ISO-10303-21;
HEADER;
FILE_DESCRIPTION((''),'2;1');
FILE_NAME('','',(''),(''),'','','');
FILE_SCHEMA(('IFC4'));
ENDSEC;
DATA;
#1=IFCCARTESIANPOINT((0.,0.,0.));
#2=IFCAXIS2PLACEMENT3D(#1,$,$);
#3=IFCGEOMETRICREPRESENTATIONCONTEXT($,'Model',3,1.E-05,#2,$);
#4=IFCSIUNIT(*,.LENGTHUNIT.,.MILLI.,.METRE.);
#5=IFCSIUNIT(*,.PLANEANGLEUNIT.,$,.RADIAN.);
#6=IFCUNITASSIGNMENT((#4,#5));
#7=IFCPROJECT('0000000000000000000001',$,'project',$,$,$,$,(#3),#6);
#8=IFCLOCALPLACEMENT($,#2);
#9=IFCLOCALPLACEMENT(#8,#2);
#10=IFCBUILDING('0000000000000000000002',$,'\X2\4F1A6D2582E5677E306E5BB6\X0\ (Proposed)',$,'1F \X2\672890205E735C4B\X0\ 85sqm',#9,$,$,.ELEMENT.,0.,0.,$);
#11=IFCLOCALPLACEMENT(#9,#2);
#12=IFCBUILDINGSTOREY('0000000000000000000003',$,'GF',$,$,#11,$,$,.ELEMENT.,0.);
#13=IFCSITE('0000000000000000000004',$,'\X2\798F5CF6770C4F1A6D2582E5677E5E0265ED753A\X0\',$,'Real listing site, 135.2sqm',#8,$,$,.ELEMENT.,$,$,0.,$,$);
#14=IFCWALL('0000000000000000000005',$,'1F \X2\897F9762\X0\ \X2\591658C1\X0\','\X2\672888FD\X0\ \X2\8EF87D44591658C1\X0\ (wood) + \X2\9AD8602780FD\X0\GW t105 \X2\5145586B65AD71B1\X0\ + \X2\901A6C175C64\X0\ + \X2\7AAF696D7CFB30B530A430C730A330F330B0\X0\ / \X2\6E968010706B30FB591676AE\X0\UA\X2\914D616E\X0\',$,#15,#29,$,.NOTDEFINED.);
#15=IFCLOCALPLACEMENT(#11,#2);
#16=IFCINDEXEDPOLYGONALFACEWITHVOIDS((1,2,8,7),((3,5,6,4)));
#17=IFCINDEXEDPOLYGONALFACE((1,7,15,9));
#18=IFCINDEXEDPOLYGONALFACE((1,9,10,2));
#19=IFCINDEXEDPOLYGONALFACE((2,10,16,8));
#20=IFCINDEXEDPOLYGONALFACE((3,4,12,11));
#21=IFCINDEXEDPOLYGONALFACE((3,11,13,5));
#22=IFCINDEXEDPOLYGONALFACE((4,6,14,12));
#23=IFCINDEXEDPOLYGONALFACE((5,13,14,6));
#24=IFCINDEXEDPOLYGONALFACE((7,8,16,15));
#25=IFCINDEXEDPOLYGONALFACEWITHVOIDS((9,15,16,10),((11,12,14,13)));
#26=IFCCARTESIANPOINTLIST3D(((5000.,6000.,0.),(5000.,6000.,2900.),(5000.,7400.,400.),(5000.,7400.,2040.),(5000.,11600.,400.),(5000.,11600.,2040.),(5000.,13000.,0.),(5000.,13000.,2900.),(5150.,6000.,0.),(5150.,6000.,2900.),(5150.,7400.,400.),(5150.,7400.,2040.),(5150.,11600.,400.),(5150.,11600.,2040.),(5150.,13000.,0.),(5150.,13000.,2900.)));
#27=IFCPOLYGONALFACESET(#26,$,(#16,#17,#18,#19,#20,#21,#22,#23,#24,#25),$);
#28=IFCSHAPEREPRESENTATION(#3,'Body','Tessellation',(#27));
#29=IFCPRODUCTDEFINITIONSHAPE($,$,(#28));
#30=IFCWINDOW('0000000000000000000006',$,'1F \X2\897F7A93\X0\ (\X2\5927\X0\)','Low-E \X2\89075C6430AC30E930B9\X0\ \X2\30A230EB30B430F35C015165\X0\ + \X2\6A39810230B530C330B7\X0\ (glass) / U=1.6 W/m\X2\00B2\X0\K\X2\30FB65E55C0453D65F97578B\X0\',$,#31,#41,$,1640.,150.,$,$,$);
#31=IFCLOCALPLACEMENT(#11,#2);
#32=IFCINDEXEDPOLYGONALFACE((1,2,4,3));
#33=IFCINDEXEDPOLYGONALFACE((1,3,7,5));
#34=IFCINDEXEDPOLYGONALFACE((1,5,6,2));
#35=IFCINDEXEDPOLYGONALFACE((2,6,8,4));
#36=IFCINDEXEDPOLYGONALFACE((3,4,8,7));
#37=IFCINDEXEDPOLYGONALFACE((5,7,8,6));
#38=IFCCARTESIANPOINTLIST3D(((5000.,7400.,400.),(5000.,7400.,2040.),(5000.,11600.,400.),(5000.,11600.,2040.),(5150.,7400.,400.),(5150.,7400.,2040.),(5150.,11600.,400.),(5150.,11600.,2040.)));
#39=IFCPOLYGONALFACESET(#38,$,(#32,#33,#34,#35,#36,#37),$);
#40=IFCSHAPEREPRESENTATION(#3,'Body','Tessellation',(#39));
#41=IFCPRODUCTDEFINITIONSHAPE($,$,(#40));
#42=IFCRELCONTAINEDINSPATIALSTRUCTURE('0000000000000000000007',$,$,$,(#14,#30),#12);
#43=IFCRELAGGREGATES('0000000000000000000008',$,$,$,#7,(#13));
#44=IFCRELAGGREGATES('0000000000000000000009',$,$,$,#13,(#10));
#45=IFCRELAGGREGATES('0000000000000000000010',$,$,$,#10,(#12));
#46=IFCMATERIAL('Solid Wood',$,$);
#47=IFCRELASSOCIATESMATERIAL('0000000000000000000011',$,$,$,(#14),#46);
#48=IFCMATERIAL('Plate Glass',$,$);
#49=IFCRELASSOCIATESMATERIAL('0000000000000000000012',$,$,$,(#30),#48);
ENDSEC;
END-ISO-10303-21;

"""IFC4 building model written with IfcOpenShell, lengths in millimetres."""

from ifc_helpers import new_model, si_unit, frame, frame_2d, origin, place, context, project, spatial, rectangle, extrude, material, element, fill, save


model = new_model("IFC4")

# Units and contexts
model_context = context("Model", 3, precision=1e-05, world=origin())
ifc_project = project(units=[si_unit("LENGTHUNIT", "METRE", prefix="MILLI"), si_unit("PLANEANGLEUNIT", "RADIAN")], contexts=[model_context])

# Site, building, storey
site_placement = place(None, origin())
site = spatial("IfcSite", under=ifc_project, at=site_placement, Name="福島県会津若松市旭町", ObjectType="Real listing site, 135.2sqm", CompositionType="ELEMENT", RefElevation=0.0)
building_placement = place(site_placement, origin())
building = spatial("IfcBuilding", under=site, at=building_placement, Name="会津若松の家 (Proposed)", ObjectType="1F 木造平屋 85sqm", CompositionType="ELEMENT", ElevationOfRefHeight=0.0, ElevationOfTerrain=0.0)
storey_placement = place(building_placement, origin())
storey = spatial("IfcBuildingStorey", under=building, at=storey_placement, Name="GF", CompositionType="ELEMENT", Elevation=0.0)

# Shared definitions
ifc_material_1 = material(Name="Solid Wood")

# Shared definitions
ifc_material_2 = material(Name="Plate Glass")

# Wall, opening, window
wall_1_placement = place(storey_placement, frame((2500.0, 3000.0, 0.0)))
wall_1 = element("IfcWall", 1, at=wall_1_placement, inside=storey, material=ifc_material_1, Name="1F 西面 外壁", Description="木製 軸組外壁 (wood) + 高性能GW t105 充填断熱 + 通気層 + 窯業系サイディング / 準耐火・外皮UA配慮", PredefinedType="NOTDEFINED", context=model_context, shape_type="SweptSolid", body=[
    extrude(rectangle(XDim=150.0, YDim=7000.0, at=frame_2d((75.0, 3500.0))), frame((2500.0, 3000.0, 0.0)), (0.0, 0.0, 1.0), 2900.0),
])
opening_1_placement = place(storey_placement, frame((2500.0, 3700.0, 200.0)))
opening_1 = element("IfcOpeningElement", 2, at=opening_1_placement, cuts=wall_1, PredefinedType="NOTDEFINED", context=model_context, shape_type="SweptSolid", body=[
    extrude(rectangle(XDim=150.0, YDim=4200.0, at=frame_2d((75.0, 2100.0))), frame((2500.0, 3700.0, 200.0)), (0.0, 0.0, 1.0), 1640.0),
])
window_1_placement = place(storey_placement, frame((2500.0, 3700.0, 200.0)))
window_1 = element("IfcWindow", 3, at=window_1_placement, inside=storey, material=ifc_material_2, Name="1F 西窓 (大)", Description="Low-E 複層ガラス アルゴン封入 + 樹脂サッシ (glass) / U=1.6 W/m²K・日射取得型", OverallHeight=1640.0, OverallWidth=150.0, context=model_context, shape_type="SweptSolid", body=[
    extrude(rectangle(XDim=150.0, YDim=4200.0, at=frame_2d((75.0, 2100.0))), frame((2500.0, 3700.0, 200.0)), (0.0, 0.0, 1.0), 1640.0),
])
fill(opening_1, window_1)

save(model, "model.ifc")
